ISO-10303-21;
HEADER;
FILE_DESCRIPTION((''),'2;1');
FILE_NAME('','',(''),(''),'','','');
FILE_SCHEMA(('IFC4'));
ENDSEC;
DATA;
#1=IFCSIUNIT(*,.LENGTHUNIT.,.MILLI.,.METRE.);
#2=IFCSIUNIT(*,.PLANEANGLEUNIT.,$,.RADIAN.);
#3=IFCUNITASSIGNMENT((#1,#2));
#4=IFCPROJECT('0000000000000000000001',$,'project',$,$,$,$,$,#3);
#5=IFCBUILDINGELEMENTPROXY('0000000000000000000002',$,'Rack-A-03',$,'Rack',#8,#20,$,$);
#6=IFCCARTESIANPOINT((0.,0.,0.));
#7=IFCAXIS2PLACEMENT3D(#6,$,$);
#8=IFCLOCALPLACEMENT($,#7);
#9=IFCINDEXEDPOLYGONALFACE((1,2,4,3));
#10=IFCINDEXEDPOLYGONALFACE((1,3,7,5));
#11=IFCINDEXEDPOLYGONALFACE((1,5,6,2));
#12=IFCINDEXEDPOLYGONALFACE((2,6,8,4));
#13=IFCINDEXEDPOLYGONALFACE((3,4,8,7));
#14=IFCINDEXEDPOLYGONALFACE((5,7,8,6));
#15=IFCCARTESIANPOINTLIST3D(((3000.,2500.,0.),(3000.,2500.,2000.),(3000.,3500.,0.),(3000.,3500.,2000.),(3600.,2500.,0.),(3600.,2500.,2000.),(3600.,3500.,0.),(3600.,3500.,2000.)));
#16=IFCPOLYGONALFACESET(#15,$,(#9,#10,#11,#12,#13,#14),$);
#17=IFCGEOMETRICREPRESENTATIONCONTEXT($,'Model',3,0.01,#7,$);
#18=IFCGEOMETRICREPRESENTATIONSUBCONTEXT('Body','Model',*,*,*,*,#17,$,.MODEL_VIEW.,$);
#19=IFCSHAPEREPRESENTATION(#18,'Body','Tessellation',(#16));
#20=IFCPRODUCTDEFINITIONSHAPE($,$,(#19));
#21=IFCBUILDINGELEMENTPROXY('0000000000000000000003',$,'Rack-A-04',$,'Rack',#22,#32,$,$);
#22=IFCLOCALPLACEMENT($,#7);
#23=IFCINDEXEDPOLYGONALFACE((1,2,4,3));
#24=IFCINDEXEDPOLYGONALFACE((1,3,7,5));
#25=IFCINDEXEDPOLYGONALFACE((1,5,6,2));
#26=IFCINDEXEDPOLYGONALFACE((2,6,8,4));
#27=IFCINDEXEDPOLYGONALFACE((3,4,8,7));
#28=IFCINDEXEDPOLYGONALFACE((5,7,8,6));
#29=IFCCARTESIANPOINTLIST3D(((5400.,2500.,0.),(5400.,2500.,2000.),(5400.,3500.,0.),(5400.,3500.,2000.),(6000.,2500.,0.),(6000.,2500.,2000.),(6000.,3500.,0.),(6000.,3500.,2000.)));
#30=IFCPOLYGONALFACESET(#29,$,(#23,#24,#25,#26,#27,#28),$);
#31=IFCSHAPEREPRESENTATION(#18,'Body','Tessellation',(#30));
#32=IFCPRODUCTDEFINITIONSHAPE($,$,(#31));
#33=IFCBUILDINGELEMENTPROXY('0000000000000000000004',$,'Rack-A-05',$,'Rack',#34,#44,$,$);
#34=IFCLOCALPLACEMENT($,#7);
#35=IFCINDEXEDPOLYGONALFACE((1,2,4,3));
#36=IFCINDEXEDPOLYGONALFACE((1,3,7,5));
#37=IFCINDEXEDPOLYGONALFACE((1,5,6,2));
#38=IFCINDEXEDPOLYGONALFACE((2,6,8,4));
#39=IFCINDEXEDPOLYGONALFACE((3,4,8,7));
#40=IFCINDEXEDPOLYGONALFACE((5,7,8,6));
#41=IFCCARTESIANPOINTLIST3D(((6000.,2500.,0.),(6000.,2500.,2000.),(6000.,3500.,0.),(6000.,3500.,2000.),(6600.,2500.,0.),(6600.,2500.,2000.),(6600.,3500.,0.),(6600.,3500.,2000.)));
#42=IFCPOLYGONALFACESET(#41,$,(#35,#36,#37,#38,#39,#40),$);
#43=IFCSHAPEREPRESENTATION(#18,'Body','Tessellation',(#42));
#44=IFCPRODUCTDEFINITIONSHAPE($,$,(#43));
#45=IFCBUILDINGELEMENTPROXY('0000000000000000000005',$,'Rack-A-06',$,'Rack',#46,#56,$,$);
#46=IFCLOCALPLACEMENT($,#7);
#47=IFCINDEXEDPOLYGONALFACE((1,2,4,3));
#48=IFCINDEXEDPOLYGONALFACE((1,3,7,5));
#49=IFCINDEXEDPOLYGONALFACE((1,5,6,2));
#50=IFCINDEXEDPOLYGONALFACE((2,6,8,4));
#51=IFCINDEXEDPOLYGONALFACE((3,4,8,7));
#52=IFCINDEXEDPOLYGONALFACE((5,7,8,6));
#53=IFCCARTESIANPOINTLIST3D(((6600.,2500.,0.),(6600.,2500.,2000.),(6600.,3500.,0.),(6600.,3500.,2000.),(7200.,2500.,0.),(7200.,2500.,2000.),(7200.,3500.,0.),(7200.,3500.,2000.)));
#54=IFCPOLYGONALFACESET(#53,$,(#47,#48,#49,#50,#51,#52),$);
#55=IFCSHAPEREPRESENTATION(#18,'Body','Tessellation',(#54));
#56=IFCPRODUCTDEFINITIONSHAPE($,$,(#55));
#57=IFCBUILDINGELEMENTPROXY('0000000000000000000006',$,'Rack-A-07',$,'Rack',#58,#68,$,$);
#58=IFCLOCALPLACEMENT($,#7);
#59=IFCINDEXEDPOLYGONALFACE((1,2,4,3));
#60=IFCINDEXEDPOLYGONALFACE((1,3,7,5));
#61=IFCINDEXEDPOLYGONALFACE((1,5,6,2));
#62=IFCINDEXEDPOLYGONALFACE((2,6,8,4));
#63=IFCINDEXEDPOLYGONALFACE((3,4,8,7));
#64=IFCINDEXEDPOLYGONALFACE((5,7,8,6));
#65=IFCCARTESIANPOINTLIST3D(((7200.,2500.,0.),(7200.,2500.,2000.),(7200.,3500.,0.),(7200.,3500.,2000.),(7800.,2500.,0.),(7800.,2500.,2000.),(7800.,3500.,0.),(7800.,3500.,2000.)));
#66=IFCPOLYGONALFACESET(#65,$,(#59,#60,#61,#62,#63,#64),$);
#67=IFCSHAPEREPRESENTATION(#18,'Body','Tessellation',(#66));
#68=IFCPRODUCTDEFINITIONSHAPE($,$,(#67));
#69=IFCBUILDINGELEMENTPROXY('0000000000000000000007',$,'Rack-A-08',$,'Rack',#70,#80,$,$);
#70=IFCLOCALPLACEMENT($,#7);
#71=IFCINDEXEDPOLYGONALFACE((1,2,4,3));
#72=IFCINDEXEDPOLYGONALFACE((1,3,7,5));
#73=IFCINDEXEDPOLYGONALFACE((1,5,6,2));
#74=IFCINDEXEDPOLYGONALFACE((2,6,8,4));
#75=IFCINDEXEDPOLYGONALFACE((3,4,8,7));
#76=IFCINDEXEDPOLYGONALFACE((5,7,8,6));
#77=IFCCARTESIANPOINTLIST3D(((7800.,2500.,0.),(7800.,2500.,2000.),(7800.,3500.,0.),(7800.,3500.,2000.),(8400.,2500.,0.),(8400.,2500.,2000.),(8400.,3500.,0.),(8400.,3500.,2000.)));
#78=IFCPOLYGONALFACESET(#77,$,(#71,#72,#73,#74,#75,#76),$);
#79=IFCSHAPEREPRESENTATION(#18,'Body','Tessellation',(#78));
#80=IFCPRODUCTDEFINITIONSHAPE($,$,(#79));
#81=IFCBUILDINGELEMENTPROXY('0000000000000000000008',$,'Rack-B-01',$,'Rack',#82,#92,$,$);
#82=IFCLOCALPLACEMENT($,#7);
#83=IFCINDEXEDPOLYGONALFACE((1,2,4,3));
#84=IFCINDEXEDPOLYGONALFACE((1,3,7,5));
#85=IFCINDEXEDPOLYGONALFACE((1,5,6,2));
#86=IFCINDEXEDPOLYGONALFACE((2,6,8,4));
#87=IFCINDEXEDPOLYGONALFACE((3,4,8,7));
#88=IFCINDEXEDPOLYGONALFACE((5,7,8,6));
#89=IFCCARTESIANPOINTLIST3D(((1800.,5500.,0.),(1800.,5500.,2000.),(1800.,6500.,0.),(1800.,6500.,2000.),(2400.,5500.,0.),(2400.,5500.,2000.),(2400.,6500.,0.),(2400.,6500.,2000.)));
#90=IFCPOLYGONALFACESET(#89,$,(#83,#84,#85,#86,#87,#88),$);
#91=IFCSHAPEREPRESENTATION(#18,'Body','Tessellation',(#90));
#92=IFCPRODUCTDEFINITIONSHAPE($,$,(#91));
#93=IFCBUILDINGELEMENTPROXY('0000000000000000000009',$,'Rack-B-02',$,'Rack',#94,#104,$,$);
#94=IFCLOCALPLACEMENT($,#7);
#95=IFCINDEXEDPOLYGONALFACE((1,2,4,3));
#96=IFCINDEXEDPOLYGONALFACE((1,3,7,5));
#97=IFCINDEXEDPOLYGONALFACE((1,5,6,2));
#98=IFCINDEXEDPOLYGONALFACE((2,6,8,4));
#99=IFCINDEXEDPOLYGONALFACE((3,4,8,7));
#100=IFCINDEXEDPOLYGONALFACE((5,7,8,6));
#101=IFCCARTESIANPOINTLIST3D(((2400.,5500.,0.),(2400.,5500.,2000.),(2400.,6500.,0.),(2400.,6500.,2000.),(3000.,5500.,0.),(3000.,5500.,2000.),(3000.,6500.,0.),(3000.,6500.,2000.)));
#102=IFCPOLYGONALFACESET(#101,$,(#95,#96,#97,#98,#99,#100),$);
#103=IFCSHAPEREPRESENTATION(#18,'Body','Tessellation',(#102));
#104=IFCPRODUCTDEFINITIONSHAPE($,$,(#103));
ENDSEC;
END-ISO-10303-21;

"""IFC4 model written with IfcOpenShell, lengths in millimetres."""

from ifc_helpers import new_model, si_unit, frame, origin, place, context, subcontext, project, rectangle, extrude, element, save


model = new_model("IFC4")

# Units and contexts
model_context = context("Model", 3, precision=0.01, world=origin())
body_context = subcontext(model_context, "Body", "Model", "MODEL_VIEW")
ifc_project = project(units=[si_unit("LENGTHUNIT", "METRE", prefix="MILLI"), si_unit("PLANEANGLEUNIT", "RADIAN")])

# Shared definitions
placement = place(None, origin())

# Building element proxies
for number, where, name in (
    (1, (3300.0, 3000.0, 0.0), "Rack-A-03"),
    (2, (5700.0, 3000.0, 0.0), "Rack-A-04"),
    (3, (6300.0, 3000.0, 0.0), "Rack-A-05"),
    (4, (6900.0, 3000.0, 0.0), "Rack-A-06"),
    (5, (7500.0, 3000.0, 0.0), "Rack-A-07"),
    (6, (8100.0, 3000.0, 0.0), "Rack-A-08"),
    (7, (2100.0, 6000.0, 0.0), "Rack-B-01"),
    (8, (2700.0, 6000.0, 0.0), "Rack-B-02"),
):
    element("IfcBuildingElementProxy", number, at=place(placement, frame(where)), Name=name, ObjectType="Rack", context=body_context, shape_type="SweptSolid", body=[
        extrude(rectangle(XDim=600.0, YDim=1000.0), origin(), (0.0, 0.0, 1.0), 2000.0),
    ])

save(model, "model.ifc")
